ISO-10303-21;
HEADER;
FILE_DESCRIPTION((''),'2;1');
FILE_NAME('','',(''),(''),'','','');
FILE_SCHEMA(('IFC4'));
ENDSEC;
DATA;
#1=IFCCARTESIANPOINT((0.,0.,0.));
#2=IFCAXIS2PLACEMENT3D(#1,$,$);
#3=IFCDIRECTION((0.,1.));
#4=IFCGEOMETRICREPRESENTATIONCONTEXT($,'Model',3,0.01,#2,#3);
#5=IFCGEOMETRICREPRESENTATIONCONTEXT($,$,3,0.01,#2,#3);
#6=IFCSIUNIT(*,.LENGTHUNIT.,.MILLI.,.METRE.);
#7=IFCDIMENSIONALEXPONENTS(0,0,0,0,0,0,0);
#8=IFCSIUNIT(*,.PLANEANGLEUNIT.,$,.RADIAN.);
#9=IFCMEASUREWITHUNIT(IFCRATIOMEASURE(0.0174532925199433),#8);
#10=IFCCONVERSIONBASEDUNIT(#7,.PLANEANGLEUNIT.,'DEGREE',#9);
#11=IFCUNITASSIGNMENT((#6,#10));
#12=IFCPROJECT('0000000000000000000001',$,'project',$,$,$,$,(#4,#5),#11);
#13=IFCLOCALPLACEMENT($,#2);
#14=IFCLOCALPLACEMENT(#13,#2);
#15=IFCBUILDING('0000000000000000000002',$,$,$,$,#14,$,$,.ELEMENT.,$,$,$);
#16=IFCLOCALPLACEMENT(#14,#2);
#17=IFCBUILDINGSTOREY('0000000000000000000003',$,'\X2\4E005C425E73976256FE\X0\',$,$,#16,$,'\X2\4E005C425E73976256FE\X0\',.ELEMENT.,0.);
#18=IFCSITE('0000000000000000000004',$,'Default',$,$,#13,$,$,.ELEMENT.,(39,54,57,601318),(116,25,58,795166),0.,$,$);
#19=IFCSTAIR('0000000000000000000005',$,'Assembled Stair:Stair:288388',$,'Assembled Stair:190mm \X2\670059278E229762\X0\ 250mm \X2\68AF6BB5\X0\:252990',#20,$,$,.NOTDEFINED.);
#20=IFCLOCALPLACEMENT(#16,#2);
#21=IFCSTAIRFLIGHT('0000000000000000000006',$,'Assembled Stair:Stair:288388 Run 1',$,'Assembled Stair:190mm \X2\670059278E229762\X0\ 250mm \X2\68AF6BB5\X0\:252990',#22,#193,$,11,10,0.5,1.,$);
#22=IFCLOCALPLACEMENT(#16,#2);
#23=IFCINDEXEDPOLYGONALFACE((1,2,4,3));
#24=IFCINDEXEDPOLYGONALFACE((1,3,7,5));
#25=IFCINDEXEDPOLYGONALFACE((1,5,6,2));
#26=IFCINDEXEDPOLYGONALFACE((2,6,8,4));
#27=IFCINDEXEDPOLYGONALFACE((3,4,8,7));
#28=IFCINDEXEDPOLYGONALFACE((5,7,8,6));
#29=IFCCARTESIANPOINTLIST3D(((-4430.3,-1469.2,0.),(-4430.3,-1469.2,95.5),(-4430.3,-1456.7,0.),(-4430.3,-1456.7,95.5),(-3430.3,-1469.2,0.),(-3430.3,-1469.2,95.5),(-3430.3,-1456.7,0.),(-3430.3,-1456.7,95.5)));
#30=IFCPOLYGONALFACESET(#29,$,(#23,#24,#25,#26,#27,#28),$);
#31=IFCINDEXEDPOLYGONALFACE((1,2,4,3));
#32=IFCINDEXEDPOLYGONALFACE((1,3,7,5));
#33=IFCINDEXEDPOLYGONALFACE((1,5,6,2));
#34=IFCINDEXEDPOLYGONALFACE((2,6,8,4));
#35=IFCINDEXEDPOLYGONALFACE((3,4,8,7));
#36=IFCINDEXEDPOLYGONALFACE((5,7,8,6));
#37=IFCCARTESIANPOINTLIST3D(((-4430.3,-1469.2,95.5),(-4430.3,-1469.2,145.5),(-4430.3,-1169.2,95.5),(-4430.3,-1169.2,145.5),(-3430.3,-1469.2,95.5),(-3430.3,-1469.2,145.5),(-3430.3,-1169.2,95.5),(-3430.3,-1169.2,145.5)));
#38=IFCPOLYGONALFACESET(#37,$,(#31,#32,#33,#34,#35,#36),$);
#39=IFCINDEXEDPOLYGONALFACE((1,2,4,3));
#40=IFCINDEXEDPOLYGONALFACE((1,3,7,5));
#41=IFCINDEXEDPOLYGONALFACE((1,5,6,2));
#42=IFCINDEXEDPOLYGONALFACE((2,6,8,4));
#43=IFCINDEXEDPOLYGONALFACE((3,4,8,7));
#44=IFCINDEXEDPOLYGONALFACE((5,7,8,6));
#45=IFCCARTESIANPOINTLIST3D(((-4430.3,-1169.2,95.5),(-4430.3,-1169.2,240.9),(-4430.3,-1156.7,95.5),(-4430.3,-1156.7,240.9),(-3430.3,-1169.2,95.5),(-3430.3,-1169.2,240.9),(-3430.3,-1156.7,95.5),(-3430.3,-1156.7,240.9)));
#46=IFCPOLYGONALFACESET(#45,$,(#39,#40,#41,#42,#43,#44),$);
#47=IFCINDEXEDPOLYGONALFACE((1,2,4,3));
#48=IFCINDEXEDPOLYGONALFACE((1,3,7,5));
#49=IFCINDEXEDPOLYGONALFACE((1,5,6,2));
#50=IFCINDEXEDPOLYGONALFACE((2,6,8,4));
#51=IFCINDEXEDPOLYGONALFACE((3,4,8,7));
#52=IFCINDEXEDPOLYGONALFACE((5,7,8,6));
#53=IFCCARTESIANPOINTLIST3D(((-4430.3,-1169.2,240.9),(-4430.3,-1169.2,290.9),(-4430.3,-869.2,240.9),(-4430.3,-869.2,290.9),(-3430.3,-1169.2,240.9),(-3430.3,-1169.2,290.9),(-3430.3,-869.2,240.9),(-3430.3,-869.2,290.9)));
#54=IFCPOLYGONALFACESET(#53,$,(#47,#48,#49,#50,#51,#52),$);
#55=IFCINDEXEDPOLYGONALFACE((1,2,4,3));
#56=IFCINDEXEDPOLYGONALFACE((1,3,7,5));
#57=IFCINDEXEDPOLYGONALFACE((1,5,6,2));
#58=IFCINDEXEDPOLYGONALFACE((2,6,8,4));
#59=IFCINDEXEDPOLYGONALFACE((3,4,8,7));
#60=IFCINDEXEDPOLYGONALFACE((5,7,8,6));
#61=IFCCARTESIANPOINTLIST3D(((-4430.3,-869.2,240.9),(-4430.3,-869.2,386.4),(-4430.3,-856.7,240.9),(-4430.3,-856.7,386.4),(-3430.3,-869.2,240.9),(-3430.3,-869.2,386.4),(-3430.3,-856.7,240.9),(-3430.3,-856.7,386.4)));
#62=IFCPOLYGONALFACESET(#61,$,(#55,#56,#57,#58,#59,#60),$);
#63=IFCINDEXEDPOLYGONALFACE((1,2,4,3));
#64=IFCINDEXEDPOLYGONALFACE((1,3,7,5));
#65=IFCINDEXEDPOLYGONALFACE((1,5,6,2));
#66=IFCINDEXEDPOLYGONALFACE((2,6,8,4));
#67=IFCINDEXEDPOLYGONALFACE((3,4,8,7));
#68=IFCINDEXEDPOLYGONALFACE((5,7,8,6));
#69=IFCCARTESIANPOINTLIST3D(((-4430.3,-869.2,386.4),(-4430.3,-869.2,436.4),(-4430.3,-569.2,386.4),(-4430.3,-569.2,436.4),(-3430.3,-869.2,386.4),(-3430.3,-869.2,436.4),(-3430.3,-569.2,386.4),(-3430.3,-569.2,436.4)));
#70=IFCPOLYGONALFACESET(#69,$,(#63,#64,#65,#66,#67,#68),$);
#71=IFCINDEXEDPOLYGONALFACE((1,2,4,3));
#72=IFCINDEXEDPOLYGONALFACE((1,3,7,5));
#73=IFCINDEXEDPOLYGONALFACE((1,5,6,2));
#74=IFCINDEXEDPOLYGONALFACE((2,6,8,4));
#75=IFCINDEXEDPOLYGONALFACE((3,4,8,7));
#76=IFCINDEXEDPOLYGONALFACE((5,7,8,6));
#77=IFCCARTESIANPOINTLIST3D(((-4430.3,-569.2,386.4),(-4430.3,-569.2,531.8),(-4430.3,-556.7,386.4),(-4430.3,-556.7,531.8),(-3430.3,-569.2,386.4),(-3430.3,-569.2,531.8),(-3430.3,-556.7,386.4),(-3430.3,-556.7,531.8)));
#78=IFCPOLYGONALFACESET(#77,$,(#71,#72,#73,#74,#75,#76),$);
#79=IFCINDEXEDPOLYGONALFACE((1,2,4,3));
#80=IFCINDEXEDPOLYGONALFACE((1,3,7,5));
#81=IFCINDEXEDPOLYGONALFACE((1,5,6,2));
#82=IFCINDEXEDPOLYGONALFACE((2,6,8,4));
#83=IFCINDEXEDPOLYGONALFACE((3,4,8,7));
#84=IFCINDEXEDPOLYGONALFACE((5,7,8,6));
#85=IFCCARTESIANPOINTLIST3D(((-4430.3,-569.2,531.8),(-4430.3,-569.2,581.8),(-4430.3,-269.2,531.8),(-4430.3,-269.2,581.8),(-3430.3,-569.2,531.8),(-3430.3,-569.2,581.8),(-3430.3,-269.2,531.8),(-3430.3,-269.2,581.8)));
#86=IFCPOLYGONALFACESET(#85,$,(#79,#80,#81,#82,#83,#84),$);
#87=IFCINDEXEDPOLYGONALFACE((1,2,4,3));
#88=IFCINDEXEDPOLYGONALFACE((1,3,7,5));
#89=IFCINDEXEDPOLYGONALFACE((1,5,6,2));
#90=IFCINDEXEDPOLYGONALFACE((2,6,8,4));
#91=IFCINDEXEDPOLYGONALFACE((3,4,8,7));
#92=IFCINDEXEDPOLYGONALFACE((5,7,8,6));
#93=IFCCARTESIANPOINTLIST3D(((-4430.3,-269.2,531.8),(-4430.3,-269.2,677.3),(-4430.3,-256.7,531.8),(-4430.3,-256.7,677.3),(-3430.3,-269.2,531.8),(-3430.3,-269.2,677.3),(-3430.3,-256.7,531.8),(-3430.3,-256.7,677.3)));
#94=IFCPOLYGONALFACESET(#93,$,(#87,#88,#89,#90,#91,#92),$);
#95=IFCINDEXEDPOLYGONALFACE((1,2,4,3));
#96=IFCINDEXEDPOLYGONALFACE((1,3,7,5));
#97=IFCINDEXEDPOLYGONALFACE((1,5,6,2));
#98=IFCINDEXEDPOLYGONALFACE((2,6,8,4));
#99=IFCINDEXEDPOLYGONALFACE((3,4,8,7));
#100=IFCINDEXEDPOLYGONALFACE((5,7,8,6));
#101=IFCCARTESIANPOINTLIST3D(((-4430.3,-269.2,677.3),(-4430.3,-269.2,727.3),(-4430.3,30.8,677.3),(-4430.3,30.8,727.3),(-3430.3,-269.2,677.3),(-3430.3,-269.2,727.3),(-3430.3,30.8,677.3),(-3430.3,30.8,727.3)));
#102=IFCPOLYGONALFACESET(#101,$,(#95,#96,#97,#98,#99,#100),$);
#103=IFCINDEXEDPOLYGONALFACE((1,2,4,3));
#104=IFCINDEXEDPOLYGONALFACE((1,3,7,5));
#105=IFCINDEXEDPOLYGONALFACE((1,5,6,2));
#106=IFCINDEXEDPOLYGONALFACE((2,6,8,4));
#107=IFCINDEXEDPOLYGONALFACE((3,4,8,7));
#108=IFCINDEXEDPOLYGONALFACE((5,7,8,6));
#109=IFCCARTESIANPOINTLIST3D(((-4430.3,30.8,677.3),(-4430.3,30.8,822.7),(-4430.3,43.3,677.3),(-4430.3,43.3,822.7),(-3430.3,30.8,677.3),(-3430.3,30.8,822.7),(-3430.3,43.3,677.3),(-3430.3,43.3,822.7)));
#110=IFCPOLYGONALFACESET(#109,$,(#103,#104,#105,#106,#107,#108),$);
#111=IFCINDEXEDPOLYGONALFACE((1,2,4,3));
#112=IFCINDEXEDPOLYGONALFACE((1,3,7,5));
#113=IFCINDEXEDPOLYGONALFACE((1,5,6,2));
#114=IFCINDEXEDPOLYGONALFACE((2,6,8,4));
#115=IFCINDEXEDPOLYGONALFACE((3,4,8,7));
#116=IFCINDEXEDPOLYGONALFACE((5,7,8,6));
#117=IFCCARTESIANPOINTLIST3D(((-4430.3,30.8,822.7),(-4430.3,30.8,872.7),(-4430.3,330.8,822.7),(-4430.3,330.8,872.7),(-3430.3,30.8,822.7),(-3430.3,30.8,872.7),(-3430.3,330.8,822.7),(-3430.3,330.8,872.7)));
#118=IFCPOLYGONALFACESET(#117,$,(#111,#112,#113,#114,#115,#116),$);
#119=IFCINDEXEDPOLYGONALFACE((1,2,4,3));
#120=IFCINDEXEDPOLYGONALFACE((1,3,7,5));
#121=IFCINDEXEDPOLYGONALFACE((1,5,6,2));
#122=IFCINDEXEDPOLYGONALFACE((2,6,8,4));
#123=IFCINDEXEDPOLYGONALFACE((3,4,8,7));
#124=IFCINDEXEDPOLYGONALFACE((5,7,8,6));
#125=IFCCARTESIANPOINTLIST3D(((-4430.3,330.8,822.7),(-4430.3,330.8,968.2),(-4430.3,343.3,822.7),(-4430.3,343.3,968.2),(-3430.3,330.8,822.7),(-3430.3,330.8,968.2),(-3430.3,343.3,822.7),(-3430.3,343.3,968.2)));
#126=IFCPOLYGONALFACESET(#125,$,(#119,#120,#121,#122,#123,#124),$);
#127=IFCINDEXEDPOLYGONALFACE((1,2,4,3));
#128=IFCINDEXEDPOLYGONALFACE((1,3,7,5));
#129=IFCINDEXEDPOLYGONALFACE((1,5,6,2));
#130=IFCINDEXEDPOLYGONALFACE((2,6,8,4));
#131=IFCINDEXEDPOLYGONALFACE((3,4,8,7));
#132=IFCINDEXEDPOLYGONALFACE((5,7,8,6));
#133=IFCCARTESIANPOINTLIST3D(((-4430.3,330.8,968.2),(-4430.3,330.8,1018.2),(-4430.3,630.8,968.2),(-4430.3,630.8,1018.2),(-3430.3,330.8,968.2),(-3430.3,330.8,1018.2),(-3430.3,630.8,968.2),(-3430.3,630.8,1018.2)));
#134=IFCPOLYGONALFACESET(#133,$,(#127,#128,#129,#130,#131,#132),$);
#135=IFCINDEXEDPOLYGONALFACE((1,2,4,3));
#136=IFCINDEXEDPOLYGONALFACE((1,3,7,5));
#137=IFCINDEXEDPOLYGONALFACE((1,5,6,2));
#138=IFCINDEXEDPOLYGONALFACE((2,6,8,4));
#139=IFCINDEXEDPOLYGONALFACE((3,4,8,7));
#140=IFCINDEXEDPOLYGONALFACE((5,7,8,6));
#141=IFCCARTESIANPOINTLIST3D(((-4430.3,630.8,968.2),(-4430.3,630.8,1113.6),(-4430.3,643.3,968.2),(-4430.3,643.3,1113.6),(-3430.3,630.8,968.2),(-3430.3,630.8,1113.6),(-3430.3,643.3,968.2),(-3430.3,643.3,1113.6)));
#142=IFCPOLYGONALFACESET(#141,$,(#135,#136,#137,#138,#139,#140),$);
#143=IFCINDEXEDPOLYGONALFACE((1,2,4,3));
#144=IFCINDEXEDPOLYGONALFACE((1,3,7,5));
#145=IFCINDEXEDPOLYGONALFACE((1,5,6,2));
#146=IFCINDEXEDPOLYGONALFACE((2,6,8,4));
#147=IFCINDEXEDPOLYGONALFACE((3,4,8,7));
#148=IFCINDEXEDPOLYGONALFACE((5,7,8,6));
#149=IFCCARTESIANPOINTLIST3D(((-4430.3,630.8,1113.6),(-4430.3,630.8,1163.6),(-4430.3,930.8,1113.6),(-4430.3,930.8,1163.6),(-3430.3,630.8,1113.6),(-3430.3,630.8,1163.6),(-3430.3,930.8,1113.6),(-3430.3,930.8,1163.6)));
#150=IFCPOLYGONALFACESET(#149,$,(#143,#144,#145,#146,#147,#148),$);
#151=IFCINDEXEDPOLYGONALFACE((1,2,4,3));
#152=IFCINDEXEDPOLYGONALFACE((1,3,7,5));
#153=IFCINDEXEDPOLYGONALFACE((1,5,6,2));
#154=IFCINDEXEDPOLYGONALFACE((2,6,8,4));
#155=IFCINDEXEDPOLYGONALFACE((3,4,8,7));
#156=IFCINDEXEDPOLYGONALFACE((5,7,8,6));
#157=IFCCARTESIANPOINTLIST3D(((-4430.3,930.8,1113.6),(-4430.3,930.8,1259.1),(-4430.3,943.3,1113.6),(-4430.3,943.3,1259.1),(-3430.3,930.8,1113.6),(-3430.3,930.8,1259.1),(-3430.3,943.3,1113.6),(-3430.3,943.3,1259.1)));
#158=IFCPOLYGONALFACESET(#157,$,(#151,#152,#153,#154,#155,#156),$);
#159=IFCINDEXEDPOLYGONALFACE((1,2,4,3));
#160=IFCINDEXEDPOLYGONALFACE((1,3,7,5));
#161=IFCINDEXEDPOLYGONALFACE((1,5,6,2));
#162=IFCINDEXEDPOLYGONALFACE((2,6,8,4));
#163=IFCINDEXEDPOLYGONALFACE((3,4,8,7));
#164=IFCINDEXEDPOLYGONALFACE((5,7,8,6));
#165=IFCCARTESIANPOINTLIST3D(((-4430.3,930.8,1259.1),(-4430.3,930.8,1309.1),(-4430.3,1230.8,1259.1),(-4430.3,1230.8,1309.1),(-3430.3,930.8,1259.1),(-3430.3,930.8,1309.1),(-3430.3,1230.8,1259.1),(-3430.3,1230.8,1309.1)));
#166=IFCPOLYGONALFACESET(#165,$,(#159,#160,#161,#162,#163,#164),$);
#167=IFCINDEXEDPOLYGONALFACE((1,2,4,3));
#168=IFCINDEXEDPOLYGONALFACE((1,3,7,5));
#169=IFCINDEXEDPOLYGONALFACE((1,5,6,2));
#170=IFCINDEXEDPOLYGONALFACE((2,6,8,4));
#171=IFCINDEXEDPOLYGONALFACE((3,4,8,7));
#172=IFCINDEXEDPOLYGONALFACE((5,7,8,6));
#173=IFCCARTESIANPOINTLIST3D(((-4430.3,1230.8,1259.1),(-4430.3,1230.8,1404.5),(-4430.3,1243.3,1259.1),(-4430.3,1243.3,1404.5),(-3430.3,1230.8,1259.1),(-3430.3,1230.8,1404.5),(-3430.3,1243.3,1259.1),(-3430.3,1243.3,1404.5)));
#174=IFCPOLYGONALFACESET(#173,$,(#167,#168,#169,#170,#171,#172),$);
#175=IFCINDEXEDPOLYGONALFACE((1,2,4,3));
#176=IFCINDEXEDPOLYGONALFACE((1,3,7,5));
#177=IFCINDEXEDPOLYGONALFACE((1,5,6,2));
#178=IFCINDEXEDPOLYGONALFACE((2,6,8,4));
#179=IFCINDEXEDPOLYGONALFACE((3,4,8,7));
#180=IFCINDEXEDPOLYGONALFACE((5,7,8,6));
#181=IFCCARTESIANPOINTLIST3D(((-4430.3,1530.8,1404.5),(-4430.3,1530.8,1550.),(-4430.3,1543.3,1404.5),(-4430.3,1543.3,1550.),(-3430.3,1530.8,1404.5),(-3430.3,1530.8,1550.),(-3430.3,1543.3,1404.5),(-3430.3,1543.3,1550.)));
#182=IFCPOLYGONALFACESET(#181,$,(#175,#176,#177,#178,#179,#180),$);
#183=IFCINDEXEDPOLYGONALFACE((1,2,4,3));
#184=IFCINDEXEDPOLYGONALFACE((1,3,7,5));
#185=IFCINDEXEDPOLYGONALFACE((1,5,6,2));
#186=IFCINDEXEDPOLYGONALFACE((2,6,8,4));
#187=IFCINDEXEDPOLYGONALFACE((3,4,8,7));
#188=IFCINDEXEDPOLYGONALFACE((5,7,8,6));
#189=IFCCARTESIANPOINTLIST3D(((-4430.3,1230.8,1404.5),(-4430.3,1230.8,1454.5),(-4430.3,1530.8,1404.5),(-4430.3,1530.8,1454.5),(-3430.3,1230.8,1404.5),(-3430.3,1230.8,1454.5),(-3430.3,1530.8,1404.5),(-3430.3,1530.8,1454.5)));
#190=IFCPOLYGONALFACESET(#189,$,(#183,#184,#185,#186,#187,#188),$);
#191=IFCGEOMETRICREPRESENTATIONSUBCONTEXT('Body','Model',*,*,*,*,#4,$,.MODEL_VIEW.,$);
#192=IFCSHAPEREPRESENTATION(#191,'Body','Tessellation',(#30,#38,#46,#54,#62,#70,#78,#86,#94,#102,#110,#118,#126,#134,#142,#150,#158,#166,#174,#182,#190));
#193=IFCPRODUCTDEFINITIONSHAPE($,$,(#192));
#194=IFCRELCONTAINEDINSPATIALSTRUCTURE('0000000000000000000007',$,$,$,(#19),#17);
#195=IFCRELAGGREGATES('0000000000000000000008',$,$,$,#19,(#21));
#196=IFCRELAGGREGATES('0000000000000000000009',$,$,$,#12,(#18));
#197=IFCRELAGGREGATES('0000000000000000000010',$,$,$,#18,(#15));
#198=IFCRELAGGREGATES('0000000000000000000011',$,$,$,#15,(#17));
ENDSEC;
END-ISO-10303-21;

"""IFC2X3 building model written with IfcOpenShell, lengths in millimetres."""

from ifc_helpers import new_model, entity, si_unit, converted_unit, direction, frame, frame_2d, origin, origin_2d_with_axis, place, context, subcontext, project, spatial, rectangle, extrude, element, aggregate, save


model = new_model("IFC2X3")

# Units and contexts
model_context = context("Model", 3, precision=0.01, world=origin(), true_north=direction((0.0, 1.0)))
context_of_model = context(None, 3, precision=0.01, world=origin(), true_north=direction((0.0, 1.0)))
body_context = subcontext(model_context, "Body", "Model", "MODEL_VIEW")
ifc_project = project(units=[si_unit("LENGTHUNIT", "METRE", prefix="MILLI"), converted_unit("PLANEANGLEUNIT", "DEGREE", entity("IfcRatioMeasure", 0.0174532925199433), si_unit("PLANEANGLEUNIT", "RADIAN"), dimensions=[0, 0, 0, 0, 0, 0, 0])], contexts=[model_context, context_of_model])

# Site, building, storey
site_placement = place(None, origin())
site = spatial("IfcSite", under=ifc_project, at=site_placement, Name="Default", CompositionType="ELEMENT", RefLatitude=(39, 54, 57, 601318), RefLongitude=(116, 25, 58, 795166), RefElevation=0.0)
building_placement = place(site_placement, origin())
building = spatial("IfcBuilding", under=site, at=building_placement, CompositionType="ELEMENT")
storey_placement = place(building_placement, origin())
storey = spatial("IfcBuildingStorey", under=building, at=storey_placement, Name="一层平面图", LongName="一层平面图", CompositionType="ELEMENT", Elevation=0.0)

# Stair
stair_placement = place(storey_placement, origin())
stair = element("IfcStair", 1, at=stair_placement, inside=storey, Name="Assembled Stair:Stair:288388", ObjectType="Assembled Stair:190mm 最大踢面 250mm 梯段:252990", ShapeType="NOTDEFINED")

# Stair flight
stair_flight_1_placement = place(stair_placement, origin())
stair_flight_1 = element("IfcStairFlight", 2, at=stair_flight_1_placement, Name="Assembled Stair:Stair:288388 Run 1", ObjectType="Assembled Stair:190mm 最大踢面 250mm 梯段:252990", NumberOfRiser=11, NumberOfTreads=10, RiserHeight=0.5, TreadLength=1.0, context=body_context, shape_type="SweptSolid", body=[
    extrude(rectangle(XDim=1000.0, YDim=12.5, at=origin_2d_with_axis()), frame((-3930.3, -1462.9, 0.0), z_axis=(0.0, 0.0, 1.0), x_axis=(-1.0, 0.0, 0.0)), (0.0, 0.0, 1.0), 95.5),
    extrude(rectangle(XDim=300.0, YDim=1000.0, at=frame_2d((0.0, 0.0), x_axis=(1.0, 0.0))), frame((-3930.3, -1319.2, 95.5), z_axis=(0.0, 0.0, 1.0), x_axis=(0.0, -1.0, 0.0)), (0.0, 0.0, 1.0), 50.0),
    extrude(rectangle(XDim=1000.0, YDim=12.5, at=origin_2d_with_axis()), frame((-3930.3, -1162.9, 95.5), z_axis=(0.0, 0.0, 1.0), x_axis=(-1.0, 0.0, 0.0)), (0.0, 0.0, 1.0), 145.5),
    extrude(rectangle(XDim=300.0, YDim=1000.0, at=frame_2d((0.0, 0.0), x_axis=(1.0, 0.0))), frame((-3930.3, -1019.2, 240.9), z_axis=(0.0, 0.0, 1.0), x_axis=(0.0, -1.0, 0.0)), (0.0, 0.0, 1.0), 50.0),
    extrude(rectangle(XDim=1000.0, YDim=12.5, at=origin_2d_with_axis()), frame((-3930.3, -862.9, 240.9), z_axis=(0.0, 0.0, 1.0), x_axis=(-1.0, 0.0, 0.0)), (0.0, 0.0, 1.0), 145.5),
    extrude(rectangle(XDim=300.0, YDim=1000.0, at=frame_2d((0.0, 0.0), x_axis=(1.0, 0.0))), frame((-3930.3, -719.2, 386.4), z_axis=(0.0, 0.0, 1.0), x_axis=(0.0, -1.0, 0.0)), (0.0, 0.0, 1.0), 50.0),
    extrude(rectangle(XDim=1000.0, YDim=12.5, at=origin_2d_with_axis()), frame((-3930.3, -562.9, 386.4), z_axis=(0.0, 0.0, 1.0), x_axis=(-1.0, 0.0, 0.0)), (0.0, 0.0, 1.0), 145.5),
    extrude(rectangle(XDim=300.0, YDim=1000.0, at=frame_2d((0.0, 0.0), x_axis=(1.0, 0.0))), frame((-3930.3, -419.2, 531.8), z_axis=(0.0, 0.0, 1.0), x_axis=(0.0, -1.0, 0.0)), (0.0, 0.0, 1.0), 50.0),
    extrude(rectangle(XDim=1000.0, YDim=12.5, at=origin_2d_with_axis()), frame((-3930.3, -262.9, 531.8), z_axis=(0.0, 0.0, 1.0), x_axis=(-1.0, 0.0, 0.0)), (0.0, 0.0, 1.0), 145.5),
    extrude(rectangle(XDim=300.0, YDim=1000.0, at=frame_2d((0.0, 0.0), x_axis=(1.0, 0.0))), frame((-3930.3, -119.2, 677.3), z_axis=(0.0, 0.0, 1.0), x_axis=(0.0, -1.0, 0.0)), (0.0, 0.0, 1.0), 50.0),
    extrude(rectangle(XDim=1000.0, YDim=12.5, at=origin_2d_with_axis()), frame((-3930.3, 37.1, 677.3), z_axis=(0.0, 0.0, 1.0), x_axis=(-1.0, 0.0, 0.0)), (0.0, 0.0, 1.0), 145.5),
    extrude(rectangle(XDim=300.0, YDim=1000.0, at=frame_2d((0.0, 0.0), x_axis=(1.0, 0.0))), frame((-3930.3, 180.8, 822.7), z_axis=(0.0, 0.0, 1.0), x_axis=(0.0, -1.0, 0.0)), (0.0, 0.0, 1.0), 50.0),
    extrude(rectangle(XDim=1000.0, YDim=12.5, at=origin_2d_with_axis()), frame((-3930.3, 337.1, 822.7), z_axis=(0.0, 0.0, 1.0), x_axis=(-1.0, 0.0, 0.0)), (0.0, 0.0, 1.0), 145.5),
    extrude(rectangle(XDim=300.0, YDim=1000.0, at=frame_2d((0.0, 0.0), x_axis=(1.0, 0.0))), frame((-3930.3, 480.8, 968.2), z_axis=(0.0, 0.0, 1.0), x_axis=(0.0, -1.0, 0.0)), (0.0, 0.0, 1.0), 50.0),
    extrude(rectangle(XDim=1000.0, YDim=12.5, at=frame_2d((0.0, 0.0), x_axis=(1.0, 0.0))), frame((-3930.3, 637.1, 968.2), z_axis=(0.0, 0.0, 1.0), x_axis=(-1.0, 0.0, 0.0)), (0.0, 0.0, 1.0), 145.5),
    extrude(rectangle(XDim=300.0, YDim=1000.0, at=frame_2d((0.0, 0.0), x_axis=(1.0, 0.0))), frame((-3930.3, 780.8, 1113.6), z_axis=(0.0, 0.0, 1.0), x_axis=(0.0, -1.0, 0.0)), (0.0, 0.0, 1.0), 50.0),
    extrude(rectangle(XDim=1000.0, YDim=12.5, at=frame_2d((0.0, 0.0), x_axis=(1.0, 0.0))), frame((-3930.3, 937.1, 1113.6), z_axis=(0.0, 0.0, 1.0), x_axis=(-1.0, 0.0, 0.0)), (0.0, 0.0, 1.0), 145.5),
    extrude(rectangle(XDim=300.0, YDim=1000.0, at=frame_2d((0.0, 0.0), x_axis=(1.0, 0.0))), frame((-3930.3, 1080.8, 1259.1), z_axis=(0.0, 0.0, 1.0), x_axis=(0.0, -1.0, 0.0)), (0.0, 0.0, 1.0), 50.0),
    extrude(rectangle(XDim=1000.0, YDim=12.5, at=origin_2d_with_axis()), frame((-3930.3, 1237.1, 1259.1), z_axis=(0.0, 0.0, 1.0), x_axis=(-1.0, 0.0, 0.0)), (0.0, 0.0, 1.0), 145.5),
    extrude(rectangle(XDim=1000.0, YDim=12.5, at=frame_2d((0.0, 0.0), x_axis=(1.0, 0.0))), frame((-3930.3, 1537.1, 1404.5), z_axis=(0.0, 0.0, 1.0), x_axis=(-1.0, 0.0, 0.0)), (0.0, 0.0, 1.0), 145.5),
    extrude(rectangle(XDim=300.0, YDim=1000.0, at=frame_2d((0.0, 0.0), x_axis=(1.0, 0.0))), frame((-3930.3, 1380.8, 1404.5), z_axis=(0.0, 0.0, 1.0), x_axis=(0.0, -1.0, 0.0)), (0.0, 0.0, 1.0), 50.0),
])
aggregate(stair, [stair_flight_1])

save(model, "model.ifc")
